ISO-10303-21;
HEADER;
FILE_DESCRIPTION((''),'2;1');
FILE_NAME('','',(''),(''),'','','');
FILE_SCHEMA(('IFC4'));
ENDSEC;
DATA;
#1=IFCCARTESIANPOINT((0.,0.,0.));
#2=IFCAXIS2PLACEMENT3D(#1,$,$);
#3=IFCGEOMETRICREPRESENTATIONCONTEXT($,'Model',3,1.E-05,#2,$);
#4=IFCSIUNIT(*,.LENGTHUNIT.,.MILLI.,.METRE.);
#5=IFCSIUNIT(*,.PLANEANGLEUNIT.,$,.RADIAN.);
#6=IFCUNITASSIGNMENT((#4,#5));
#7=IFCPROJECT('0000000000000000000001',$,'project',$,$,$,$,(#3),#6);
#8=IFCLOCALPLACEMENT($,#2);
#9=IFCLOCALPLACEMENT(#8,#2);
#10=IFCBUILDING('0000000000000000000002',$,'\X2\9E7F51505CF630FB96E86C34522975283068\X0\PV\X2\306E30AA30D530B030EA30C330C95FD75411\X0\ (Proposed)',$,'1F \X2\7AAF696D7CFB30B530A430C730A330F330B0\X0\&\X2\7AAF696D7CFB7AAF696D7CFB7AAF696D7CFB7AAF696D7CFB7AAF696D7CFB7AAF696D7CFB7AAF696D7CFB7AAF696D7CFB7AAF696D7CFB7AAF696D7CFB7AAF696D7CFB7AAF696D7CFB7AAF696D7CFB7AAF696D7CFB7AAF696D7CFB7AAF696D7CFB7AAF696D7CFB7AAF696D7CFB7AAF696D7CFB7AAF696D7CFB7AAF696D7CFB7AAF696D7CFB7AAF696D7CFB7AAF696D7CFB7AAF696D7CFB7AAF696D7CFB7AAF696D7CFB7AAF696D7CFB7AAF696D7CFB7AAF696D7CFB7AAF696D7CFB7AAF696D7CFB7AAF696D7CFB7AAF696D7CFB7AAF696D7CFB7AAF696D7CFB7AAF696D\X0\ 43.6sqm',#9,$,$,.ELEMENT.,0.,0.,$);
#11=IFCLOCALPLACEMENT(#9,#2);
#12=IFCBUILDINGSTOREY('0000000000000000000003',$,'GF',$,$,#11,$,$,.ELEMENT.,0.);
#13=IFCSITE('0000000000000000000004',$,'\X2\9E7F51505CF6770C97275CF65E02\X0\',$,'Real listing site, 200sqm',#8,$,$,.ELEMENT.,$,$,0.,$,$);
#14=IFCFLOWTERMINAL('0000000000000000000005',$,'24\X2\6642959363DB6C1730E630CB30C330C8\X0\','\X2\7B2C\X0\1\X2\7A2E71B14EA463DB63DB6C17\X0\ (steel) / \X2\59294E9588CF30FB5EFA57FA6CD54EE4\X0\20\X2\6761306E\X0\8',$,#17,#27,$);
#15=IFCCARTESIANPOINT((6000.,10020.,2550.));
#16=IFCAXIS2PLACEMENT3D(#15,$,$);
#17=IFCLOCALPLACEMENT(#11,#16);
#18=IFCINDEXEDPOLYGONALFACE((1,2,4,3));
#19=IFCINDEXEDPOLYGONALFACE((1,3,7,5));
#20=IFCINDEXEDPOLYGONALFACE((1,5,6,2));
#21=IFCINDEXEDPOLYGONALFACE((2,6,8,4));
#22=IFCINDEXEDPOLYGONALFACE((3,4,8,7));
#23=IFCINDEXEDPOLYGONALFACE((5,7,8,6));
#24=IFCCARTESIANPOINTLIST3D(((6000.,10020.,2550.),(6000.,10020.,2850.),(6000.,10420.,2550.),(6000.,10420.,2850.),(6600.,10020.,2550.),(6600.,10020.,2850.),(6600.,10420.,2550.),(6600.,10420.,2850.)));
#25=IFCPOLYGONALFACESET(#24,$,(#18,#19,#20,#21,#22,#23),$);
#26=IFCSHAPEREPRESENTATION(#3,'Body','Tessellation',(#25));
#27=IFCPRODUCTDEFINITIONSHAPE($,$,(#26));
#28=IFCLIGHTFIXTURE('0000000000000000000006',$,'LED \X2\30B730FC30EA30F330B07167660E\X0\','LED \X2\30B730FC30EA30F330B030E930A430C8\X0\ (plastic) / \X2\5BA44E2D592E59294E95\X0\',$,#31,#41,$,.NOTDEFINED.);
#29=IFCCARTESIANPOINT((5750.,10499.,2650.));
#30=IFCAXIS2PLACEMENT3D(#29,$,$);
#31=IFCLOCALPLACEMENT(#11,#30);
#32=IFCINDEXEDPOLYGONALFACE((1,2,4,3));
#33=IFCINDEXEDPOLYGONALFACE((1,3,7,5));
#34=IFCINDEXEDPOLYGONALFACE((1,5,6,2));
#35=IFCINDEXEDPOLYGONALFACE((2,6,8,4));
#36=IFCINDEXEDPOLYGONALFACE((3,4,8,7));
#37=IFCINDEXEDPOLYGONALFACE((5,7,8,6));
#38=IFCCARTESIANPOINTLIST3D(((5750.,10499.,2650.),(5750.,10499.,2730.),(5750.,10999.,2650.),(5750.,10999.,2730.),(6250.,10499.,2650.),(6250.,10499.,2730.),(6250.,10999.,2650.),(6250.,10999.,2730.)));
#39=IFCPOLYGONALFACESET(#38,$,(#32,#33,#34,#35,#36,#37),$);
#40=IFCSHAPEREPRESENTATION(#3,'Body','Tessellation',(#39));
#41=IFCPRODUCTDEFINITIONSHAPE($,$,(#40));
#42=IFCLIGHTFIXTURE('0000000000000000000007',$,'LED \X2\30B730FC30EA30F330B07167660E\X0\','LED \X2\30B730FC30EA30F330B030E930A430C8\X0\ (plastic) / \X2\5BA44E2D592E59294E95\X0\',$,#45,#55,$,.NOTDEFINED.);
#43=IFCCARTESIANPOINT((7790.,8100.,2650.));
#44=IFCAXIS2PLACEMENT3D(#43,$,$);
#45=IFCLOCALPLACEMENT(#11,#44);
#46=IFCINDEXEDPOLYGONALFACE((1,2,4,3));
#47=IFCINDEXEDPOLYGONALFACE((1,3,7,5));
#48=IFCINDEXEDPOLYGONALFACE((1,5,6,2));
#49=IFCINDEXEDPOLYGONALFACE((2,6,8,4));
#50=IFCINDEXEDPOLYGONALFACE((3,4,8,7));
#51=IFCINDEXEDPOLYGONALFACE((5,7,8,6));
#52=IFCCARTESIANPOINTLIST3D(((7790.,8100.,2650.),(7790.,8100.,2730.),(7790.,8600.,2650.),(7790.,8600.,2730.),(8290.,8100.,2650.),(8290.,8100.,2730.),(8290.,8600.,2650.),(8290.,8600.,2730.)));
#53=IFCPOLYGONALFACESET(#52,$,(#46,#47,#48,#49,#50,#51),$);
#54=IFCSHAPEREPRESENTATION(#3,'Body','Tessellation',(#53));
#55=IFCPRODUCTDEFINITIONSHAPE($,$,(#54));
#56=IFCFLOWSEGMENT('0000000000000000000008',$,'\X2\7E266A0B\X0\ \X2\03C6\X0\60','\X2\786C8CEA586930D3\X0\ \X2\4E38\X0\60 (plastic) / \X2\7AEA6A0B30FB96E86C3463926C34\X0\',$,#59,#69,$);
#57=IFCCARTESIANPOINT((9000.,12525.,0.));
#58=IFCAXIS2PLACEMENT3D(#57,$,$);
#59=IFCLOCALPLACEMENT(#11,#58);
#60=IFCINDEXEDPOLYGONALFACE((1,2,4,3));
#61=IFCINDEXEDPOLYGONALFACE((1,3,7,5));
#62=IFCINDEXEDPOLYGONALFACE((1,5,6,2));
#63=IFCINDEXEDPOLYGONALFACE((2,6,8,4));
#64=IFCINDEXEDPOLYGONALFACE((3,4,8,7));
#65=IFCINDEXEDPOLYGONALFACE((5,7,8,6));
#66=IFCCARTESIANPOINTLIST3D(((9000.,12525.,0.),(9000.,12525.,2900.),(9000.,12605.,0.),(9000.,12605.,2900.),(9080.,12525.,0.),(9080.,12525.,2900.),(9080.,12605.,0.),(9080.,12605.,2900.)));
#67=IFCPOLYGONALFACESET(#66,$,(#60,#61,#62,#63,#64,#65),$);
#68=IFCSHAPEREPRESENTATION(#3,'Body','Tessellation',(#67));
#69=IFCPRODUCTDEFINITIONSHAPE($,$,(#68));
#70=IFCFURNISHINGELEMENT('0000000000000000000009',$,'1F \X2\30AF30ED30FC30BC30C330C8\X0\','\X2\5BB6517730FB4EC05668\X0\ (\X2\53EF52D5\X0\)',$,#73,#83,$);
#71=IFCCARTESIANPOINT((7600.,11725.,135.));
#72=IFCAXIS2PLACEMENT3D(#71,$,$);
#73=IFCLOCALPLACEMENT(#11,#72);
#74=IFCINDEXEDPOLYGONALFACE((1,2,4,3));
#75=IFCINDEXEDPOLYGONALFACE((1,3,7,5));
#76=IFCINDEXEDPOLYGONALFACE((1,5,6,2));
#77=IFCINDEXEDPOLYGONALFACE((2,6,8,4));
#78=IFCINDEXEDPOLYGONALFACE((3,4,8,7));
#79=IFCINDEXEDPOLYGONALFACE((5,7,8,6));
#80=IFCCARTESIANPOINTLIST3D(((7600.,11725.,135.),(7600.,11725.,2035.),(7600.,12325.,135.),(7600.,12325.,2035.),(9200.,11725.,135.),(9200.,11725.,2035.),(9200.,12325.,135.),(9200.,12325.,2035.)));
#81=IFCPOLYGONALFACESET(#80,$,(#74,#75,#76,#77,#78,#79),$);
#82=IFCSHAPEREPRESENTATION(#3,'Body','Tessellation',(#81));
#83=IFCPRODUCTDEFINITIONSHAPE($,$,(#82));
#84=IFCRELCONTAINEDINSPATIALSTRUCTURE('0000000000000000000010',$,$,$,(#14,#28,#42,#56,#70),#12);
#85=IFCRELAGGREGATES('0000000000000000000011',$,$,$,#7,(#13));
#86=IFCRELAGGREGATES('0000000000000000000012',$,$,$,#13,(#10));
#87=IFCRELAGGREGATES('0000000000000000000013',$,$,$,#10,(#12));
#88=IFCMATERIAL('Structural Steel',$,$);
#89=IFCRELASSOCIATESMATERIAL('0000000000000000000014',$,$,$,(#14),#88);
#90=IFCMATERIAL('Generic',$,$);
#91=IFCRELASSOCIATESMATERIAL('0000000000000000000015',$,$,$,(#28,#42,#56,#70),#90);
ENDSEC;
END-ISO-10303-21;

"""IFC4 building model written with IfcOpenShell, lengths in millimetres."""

from ifc_helpers import new_model, si_unit, frame, frame_2d, origin, place, context, project, spatial, rectangle, extrude, material, element, save


model = new_model("IFC4")

# Units and contexts
model_context = context("Model", 3, precision=1e-05, world=origin())
ifc_project = project(units=[si_unit("LENGTHUNIT", "METRE", prefix="MILLI"), si_unit("PLANEANGLEUNIT", "RADIAN")], contexts=[model_context])

# Site, building, storey
site_placement = place(None, origin())
site = spatial("IfcSite", under=ifc_project, at=site_placement, Name="鹿児島県霧島市", ObjectType="Real listing site, 200sqm", CompositionType="ELEMENT", RefElevation=0.0)
building_placement = place(site_placement, origin())
building = spatial("IfcBuilding", under=site, at=building_placement, Name="鹿児島・雨水利用とPVのオフグリッド志向 (Proposed)", ObjectType="1F 窯業系サイディング&窯業系窯業系窯業系窯業系窯業系窯業系窯業系窯業系窯業系窯業系窯業系窯業系窯業系窯業系窯業系窯業系窯業系窯業系窯業系窯業系窯業系窯業系窯業系窯業系窯業系窯業系窯業系窯業系窯業系窯業系窯業系窯業系窯業系窯業系窯業系窯業系窯業 43.6sqm", CompositionType="ELEMENT", ElevationOfRefHeight=0.0, ElevationOfTerrain=0.0)
storey_placement = place(building_placement, origin())
storey = spatial("IfcBuildingStorey", under=building, at=storey_placement, Name="GF", CompositionType="ELEMENT", Elevation=0.0)

# Shared definitions
ifc_material_1 = material(Name="Generic")

# Flow terminal
ifc_material_2 = material(Name="Structural Steel")
flow_terminal_placement = place(storey_placement, frame((6000.0, 10020.0, 2550.0)))
element("IfcFlowTerminal", 1, at=flow_terminal_placement, inside=storey, material=ifc_material_2, Name="24時間換気ユニット", Description="第1種熱交換換気 (steel) / 天井裏・建基法令20条の8", context=model_context, shape_type="SweptSolid", body=[
    extrude(rectangle(XDim=600.0, YDim=400.0, at=frame_2d((300.0, 200.0))), frame((6000.0, 10020.0, 2550.0)), (0.0, 0.0, 1.0), 300.0),
])

# Light fixtures
light_fixture_1_placement = place(storey_placement, frame((5750.0, 10499.0, 2650.0)))
element("IfcLightFixture", 2, at=light_fixture_1_placement, inside=storey, material=ifc_material_1, Name="LED シーリング照明", Description="LED シーリングライト (plastic) / 室中央天井", PredefinedType="NOTDEFINED", context=model_context, shape_type="SweptSolid", body=[
    extrude(rectangle(XDim=500.0, YDim=500.0, at=frame_2d((250.0, 250.0))), frame((5750.0, 10499.0, 2650.0)), (0.0, 0.0, 1.0), 80.0),
])
light_fixture_2_placement = place(storey_placement, frame((7790.0, 8100.0, 2650.0)))
element("IfcLightFixture", 3, at=light_fixture_2_placement, inside=storey, material=ifc_material_1, Name="LED シーリング照明", Description="LED シーリングライト (plastic) / 室中央天井", PredefinedType="NOTDEFINED", context=model_context, shape_type="SweptSolid", body=[
    extrude(rectangle(XDim=500.0, YDim=500.0, at=frame_2d((250.0, 250.0))), frame((7790.0, 8100.0, 2650.0)), (0.0, 0.0, 1.0), 80.0),
])

# Flow segment
flow_segment_placement = place(storey_placement, frame((9000.0, 12525.0, 0.0)))
element("IfcFlowSegment", 4, at=flow_segment_placement, inside=storey, material=ifc_material_1, Name="縦樋 φ60", Description="硬質塩ビ 丸60 (plastic) / 竪樋・雨水排水", context=model_context, shape_type="SweptSolid", body=[
    extrude(rectangle(XDim=80.0, YDim=80.0, at=frame_2d((40.0, 40.0))), frame((9000.0, 12525.0, 0.0)), (0.0, 0.0, 1.0), 2900.0),
])

# Furnishing element
furnishing_placement = place(storey_placement, frame((7600.0, 11725.0, 135.0)))
element("IfcFurnishingElement", 5, at=furnishing_placement, inside=storey, material=ifc_material_1, Name="1F クローゼット", Description="家具・什器 (可動)", context=model_context, shape_type="SweptSolid", body=[
    extrude(rectangle(XDim=1600.0, YDim=600.0, at=frame_2d((800.0, 300.0))), frame((7600.0, 11725.0, 135.0)), (0.0, 0.0, 1.0), 1900.0),
])

save(model, "model.ifc")
